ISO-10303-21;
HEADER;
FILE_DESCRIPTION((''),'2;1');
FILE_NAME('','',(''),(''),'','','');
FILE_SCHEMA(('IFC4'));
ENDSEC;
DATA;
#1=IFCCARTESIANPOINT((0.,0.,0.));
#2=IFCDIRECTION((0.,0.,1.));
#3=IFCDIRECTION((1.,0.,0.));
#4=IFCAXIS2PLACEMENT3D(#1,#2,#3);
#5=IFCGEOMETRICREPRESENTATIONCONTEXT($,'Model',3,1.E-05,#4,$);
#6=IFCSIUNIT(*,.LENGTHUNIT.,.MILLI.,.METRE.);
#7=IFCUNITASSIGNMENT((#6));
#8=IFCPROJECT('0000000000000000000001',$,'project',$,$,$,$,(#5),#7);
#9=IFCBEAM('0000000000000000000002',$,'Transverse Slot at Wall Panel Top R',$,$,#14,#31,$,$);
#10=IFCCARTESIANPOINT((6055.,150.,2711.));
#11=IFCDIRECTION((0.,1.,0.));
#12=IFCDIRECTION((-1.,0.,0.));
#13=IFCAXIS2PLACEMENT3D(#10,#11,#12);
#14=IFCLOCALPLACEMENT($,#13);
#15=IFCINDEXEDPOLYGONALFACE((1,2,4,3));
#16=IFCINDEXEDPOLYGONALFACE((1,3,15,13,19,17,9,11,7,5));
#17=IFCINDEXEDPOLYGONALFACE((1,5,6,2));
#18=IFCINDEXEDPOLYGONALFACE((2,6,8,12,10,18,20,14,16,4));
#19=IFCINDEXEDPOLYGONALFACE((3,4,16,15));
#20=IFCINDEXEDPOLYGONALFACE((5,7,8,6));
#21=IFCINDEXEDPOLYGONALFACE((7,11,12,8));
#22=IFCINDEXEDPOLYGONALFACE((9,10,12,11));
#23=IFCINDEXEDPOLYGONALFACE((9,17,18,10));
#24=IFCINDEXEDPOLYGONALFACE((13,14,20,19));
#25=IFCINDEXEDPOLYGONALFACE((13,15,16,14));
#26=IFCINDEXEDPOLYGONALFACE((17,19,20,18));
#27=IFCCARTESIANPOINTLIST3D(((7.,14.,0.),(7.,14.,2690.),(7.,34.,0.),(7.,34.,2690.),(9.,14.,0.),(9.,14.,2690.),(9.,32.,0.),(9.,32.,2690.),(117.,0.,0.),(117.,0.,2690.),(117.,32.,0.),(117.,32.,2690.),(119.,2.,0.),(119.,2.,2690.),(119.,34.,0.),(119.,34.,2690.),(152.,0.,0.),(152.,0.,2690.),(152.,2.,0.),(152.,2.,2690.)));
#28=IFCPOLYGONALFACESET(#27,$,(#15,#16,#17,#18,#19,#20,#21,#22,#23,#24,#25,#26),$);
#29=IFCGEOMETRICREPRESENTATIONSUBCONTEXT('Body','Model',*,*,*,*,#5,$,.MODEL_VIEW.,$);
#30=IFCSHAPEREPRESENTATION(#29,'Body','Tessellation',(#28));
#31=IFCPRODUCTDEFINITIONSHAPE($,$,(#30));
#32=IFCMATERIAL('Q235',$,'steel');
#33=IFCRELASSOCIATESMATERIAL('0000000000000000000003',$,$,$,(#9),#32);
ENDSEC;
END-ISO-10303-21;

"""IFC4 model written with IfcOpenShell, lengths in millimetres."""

from ifc_helpers import new_model, si_unit, frame, origin_with_axes, place, context, subcontext, project, line, indexed_curve, outline, extrude, material, element, save


model = new_model("IFC4")

# Units and contexts
model_context = context("Model", 3, precision=1e-05, world=origin_with_axes())
body_context = subcontext(model_context, "Body", "Model", "MODEL_VIEW")
ifc_project = project(units=[si_unit("LENGTHUNIT", "METRE", prefix="MILLI")], contexts=[model_context])

# Beam
ifc_material_1 = material(Name="Q235", Category="steel")
beam_1_placement = place(None, frame((6055.0, 150.0, 2711.0), z_axis=(0.0, 1.0, 0.0), x_axis=(-1.0, 0.0, 0.0)))
element("IfcBeam", 1, at=beam_1_placement, material=ifc_material_1, Name="Transverse Slot at Wall Panel Top R", context=body_context, shape_type="SweptSolid", body=[
    extrude(outline(indexed_curve([(152.0, 0.0), (117.0, 0.0), (117.0, 32.0), (9.0, 32.0), (9.0, 14.0), (7.0, 14.0), (7.0, 34.0), (119.0, 34.0), (119.0, 2.0), (152.0, 2.0), (152.0, 0.0)], segments=[line(1, 2, 3, 4, 5, 6, 7, 8, 9, 10, 11, 1)])), origin_with_axes(), (0.0, 0.0, 1.0), 2690.0),
])

save(model, "model.ifc")
